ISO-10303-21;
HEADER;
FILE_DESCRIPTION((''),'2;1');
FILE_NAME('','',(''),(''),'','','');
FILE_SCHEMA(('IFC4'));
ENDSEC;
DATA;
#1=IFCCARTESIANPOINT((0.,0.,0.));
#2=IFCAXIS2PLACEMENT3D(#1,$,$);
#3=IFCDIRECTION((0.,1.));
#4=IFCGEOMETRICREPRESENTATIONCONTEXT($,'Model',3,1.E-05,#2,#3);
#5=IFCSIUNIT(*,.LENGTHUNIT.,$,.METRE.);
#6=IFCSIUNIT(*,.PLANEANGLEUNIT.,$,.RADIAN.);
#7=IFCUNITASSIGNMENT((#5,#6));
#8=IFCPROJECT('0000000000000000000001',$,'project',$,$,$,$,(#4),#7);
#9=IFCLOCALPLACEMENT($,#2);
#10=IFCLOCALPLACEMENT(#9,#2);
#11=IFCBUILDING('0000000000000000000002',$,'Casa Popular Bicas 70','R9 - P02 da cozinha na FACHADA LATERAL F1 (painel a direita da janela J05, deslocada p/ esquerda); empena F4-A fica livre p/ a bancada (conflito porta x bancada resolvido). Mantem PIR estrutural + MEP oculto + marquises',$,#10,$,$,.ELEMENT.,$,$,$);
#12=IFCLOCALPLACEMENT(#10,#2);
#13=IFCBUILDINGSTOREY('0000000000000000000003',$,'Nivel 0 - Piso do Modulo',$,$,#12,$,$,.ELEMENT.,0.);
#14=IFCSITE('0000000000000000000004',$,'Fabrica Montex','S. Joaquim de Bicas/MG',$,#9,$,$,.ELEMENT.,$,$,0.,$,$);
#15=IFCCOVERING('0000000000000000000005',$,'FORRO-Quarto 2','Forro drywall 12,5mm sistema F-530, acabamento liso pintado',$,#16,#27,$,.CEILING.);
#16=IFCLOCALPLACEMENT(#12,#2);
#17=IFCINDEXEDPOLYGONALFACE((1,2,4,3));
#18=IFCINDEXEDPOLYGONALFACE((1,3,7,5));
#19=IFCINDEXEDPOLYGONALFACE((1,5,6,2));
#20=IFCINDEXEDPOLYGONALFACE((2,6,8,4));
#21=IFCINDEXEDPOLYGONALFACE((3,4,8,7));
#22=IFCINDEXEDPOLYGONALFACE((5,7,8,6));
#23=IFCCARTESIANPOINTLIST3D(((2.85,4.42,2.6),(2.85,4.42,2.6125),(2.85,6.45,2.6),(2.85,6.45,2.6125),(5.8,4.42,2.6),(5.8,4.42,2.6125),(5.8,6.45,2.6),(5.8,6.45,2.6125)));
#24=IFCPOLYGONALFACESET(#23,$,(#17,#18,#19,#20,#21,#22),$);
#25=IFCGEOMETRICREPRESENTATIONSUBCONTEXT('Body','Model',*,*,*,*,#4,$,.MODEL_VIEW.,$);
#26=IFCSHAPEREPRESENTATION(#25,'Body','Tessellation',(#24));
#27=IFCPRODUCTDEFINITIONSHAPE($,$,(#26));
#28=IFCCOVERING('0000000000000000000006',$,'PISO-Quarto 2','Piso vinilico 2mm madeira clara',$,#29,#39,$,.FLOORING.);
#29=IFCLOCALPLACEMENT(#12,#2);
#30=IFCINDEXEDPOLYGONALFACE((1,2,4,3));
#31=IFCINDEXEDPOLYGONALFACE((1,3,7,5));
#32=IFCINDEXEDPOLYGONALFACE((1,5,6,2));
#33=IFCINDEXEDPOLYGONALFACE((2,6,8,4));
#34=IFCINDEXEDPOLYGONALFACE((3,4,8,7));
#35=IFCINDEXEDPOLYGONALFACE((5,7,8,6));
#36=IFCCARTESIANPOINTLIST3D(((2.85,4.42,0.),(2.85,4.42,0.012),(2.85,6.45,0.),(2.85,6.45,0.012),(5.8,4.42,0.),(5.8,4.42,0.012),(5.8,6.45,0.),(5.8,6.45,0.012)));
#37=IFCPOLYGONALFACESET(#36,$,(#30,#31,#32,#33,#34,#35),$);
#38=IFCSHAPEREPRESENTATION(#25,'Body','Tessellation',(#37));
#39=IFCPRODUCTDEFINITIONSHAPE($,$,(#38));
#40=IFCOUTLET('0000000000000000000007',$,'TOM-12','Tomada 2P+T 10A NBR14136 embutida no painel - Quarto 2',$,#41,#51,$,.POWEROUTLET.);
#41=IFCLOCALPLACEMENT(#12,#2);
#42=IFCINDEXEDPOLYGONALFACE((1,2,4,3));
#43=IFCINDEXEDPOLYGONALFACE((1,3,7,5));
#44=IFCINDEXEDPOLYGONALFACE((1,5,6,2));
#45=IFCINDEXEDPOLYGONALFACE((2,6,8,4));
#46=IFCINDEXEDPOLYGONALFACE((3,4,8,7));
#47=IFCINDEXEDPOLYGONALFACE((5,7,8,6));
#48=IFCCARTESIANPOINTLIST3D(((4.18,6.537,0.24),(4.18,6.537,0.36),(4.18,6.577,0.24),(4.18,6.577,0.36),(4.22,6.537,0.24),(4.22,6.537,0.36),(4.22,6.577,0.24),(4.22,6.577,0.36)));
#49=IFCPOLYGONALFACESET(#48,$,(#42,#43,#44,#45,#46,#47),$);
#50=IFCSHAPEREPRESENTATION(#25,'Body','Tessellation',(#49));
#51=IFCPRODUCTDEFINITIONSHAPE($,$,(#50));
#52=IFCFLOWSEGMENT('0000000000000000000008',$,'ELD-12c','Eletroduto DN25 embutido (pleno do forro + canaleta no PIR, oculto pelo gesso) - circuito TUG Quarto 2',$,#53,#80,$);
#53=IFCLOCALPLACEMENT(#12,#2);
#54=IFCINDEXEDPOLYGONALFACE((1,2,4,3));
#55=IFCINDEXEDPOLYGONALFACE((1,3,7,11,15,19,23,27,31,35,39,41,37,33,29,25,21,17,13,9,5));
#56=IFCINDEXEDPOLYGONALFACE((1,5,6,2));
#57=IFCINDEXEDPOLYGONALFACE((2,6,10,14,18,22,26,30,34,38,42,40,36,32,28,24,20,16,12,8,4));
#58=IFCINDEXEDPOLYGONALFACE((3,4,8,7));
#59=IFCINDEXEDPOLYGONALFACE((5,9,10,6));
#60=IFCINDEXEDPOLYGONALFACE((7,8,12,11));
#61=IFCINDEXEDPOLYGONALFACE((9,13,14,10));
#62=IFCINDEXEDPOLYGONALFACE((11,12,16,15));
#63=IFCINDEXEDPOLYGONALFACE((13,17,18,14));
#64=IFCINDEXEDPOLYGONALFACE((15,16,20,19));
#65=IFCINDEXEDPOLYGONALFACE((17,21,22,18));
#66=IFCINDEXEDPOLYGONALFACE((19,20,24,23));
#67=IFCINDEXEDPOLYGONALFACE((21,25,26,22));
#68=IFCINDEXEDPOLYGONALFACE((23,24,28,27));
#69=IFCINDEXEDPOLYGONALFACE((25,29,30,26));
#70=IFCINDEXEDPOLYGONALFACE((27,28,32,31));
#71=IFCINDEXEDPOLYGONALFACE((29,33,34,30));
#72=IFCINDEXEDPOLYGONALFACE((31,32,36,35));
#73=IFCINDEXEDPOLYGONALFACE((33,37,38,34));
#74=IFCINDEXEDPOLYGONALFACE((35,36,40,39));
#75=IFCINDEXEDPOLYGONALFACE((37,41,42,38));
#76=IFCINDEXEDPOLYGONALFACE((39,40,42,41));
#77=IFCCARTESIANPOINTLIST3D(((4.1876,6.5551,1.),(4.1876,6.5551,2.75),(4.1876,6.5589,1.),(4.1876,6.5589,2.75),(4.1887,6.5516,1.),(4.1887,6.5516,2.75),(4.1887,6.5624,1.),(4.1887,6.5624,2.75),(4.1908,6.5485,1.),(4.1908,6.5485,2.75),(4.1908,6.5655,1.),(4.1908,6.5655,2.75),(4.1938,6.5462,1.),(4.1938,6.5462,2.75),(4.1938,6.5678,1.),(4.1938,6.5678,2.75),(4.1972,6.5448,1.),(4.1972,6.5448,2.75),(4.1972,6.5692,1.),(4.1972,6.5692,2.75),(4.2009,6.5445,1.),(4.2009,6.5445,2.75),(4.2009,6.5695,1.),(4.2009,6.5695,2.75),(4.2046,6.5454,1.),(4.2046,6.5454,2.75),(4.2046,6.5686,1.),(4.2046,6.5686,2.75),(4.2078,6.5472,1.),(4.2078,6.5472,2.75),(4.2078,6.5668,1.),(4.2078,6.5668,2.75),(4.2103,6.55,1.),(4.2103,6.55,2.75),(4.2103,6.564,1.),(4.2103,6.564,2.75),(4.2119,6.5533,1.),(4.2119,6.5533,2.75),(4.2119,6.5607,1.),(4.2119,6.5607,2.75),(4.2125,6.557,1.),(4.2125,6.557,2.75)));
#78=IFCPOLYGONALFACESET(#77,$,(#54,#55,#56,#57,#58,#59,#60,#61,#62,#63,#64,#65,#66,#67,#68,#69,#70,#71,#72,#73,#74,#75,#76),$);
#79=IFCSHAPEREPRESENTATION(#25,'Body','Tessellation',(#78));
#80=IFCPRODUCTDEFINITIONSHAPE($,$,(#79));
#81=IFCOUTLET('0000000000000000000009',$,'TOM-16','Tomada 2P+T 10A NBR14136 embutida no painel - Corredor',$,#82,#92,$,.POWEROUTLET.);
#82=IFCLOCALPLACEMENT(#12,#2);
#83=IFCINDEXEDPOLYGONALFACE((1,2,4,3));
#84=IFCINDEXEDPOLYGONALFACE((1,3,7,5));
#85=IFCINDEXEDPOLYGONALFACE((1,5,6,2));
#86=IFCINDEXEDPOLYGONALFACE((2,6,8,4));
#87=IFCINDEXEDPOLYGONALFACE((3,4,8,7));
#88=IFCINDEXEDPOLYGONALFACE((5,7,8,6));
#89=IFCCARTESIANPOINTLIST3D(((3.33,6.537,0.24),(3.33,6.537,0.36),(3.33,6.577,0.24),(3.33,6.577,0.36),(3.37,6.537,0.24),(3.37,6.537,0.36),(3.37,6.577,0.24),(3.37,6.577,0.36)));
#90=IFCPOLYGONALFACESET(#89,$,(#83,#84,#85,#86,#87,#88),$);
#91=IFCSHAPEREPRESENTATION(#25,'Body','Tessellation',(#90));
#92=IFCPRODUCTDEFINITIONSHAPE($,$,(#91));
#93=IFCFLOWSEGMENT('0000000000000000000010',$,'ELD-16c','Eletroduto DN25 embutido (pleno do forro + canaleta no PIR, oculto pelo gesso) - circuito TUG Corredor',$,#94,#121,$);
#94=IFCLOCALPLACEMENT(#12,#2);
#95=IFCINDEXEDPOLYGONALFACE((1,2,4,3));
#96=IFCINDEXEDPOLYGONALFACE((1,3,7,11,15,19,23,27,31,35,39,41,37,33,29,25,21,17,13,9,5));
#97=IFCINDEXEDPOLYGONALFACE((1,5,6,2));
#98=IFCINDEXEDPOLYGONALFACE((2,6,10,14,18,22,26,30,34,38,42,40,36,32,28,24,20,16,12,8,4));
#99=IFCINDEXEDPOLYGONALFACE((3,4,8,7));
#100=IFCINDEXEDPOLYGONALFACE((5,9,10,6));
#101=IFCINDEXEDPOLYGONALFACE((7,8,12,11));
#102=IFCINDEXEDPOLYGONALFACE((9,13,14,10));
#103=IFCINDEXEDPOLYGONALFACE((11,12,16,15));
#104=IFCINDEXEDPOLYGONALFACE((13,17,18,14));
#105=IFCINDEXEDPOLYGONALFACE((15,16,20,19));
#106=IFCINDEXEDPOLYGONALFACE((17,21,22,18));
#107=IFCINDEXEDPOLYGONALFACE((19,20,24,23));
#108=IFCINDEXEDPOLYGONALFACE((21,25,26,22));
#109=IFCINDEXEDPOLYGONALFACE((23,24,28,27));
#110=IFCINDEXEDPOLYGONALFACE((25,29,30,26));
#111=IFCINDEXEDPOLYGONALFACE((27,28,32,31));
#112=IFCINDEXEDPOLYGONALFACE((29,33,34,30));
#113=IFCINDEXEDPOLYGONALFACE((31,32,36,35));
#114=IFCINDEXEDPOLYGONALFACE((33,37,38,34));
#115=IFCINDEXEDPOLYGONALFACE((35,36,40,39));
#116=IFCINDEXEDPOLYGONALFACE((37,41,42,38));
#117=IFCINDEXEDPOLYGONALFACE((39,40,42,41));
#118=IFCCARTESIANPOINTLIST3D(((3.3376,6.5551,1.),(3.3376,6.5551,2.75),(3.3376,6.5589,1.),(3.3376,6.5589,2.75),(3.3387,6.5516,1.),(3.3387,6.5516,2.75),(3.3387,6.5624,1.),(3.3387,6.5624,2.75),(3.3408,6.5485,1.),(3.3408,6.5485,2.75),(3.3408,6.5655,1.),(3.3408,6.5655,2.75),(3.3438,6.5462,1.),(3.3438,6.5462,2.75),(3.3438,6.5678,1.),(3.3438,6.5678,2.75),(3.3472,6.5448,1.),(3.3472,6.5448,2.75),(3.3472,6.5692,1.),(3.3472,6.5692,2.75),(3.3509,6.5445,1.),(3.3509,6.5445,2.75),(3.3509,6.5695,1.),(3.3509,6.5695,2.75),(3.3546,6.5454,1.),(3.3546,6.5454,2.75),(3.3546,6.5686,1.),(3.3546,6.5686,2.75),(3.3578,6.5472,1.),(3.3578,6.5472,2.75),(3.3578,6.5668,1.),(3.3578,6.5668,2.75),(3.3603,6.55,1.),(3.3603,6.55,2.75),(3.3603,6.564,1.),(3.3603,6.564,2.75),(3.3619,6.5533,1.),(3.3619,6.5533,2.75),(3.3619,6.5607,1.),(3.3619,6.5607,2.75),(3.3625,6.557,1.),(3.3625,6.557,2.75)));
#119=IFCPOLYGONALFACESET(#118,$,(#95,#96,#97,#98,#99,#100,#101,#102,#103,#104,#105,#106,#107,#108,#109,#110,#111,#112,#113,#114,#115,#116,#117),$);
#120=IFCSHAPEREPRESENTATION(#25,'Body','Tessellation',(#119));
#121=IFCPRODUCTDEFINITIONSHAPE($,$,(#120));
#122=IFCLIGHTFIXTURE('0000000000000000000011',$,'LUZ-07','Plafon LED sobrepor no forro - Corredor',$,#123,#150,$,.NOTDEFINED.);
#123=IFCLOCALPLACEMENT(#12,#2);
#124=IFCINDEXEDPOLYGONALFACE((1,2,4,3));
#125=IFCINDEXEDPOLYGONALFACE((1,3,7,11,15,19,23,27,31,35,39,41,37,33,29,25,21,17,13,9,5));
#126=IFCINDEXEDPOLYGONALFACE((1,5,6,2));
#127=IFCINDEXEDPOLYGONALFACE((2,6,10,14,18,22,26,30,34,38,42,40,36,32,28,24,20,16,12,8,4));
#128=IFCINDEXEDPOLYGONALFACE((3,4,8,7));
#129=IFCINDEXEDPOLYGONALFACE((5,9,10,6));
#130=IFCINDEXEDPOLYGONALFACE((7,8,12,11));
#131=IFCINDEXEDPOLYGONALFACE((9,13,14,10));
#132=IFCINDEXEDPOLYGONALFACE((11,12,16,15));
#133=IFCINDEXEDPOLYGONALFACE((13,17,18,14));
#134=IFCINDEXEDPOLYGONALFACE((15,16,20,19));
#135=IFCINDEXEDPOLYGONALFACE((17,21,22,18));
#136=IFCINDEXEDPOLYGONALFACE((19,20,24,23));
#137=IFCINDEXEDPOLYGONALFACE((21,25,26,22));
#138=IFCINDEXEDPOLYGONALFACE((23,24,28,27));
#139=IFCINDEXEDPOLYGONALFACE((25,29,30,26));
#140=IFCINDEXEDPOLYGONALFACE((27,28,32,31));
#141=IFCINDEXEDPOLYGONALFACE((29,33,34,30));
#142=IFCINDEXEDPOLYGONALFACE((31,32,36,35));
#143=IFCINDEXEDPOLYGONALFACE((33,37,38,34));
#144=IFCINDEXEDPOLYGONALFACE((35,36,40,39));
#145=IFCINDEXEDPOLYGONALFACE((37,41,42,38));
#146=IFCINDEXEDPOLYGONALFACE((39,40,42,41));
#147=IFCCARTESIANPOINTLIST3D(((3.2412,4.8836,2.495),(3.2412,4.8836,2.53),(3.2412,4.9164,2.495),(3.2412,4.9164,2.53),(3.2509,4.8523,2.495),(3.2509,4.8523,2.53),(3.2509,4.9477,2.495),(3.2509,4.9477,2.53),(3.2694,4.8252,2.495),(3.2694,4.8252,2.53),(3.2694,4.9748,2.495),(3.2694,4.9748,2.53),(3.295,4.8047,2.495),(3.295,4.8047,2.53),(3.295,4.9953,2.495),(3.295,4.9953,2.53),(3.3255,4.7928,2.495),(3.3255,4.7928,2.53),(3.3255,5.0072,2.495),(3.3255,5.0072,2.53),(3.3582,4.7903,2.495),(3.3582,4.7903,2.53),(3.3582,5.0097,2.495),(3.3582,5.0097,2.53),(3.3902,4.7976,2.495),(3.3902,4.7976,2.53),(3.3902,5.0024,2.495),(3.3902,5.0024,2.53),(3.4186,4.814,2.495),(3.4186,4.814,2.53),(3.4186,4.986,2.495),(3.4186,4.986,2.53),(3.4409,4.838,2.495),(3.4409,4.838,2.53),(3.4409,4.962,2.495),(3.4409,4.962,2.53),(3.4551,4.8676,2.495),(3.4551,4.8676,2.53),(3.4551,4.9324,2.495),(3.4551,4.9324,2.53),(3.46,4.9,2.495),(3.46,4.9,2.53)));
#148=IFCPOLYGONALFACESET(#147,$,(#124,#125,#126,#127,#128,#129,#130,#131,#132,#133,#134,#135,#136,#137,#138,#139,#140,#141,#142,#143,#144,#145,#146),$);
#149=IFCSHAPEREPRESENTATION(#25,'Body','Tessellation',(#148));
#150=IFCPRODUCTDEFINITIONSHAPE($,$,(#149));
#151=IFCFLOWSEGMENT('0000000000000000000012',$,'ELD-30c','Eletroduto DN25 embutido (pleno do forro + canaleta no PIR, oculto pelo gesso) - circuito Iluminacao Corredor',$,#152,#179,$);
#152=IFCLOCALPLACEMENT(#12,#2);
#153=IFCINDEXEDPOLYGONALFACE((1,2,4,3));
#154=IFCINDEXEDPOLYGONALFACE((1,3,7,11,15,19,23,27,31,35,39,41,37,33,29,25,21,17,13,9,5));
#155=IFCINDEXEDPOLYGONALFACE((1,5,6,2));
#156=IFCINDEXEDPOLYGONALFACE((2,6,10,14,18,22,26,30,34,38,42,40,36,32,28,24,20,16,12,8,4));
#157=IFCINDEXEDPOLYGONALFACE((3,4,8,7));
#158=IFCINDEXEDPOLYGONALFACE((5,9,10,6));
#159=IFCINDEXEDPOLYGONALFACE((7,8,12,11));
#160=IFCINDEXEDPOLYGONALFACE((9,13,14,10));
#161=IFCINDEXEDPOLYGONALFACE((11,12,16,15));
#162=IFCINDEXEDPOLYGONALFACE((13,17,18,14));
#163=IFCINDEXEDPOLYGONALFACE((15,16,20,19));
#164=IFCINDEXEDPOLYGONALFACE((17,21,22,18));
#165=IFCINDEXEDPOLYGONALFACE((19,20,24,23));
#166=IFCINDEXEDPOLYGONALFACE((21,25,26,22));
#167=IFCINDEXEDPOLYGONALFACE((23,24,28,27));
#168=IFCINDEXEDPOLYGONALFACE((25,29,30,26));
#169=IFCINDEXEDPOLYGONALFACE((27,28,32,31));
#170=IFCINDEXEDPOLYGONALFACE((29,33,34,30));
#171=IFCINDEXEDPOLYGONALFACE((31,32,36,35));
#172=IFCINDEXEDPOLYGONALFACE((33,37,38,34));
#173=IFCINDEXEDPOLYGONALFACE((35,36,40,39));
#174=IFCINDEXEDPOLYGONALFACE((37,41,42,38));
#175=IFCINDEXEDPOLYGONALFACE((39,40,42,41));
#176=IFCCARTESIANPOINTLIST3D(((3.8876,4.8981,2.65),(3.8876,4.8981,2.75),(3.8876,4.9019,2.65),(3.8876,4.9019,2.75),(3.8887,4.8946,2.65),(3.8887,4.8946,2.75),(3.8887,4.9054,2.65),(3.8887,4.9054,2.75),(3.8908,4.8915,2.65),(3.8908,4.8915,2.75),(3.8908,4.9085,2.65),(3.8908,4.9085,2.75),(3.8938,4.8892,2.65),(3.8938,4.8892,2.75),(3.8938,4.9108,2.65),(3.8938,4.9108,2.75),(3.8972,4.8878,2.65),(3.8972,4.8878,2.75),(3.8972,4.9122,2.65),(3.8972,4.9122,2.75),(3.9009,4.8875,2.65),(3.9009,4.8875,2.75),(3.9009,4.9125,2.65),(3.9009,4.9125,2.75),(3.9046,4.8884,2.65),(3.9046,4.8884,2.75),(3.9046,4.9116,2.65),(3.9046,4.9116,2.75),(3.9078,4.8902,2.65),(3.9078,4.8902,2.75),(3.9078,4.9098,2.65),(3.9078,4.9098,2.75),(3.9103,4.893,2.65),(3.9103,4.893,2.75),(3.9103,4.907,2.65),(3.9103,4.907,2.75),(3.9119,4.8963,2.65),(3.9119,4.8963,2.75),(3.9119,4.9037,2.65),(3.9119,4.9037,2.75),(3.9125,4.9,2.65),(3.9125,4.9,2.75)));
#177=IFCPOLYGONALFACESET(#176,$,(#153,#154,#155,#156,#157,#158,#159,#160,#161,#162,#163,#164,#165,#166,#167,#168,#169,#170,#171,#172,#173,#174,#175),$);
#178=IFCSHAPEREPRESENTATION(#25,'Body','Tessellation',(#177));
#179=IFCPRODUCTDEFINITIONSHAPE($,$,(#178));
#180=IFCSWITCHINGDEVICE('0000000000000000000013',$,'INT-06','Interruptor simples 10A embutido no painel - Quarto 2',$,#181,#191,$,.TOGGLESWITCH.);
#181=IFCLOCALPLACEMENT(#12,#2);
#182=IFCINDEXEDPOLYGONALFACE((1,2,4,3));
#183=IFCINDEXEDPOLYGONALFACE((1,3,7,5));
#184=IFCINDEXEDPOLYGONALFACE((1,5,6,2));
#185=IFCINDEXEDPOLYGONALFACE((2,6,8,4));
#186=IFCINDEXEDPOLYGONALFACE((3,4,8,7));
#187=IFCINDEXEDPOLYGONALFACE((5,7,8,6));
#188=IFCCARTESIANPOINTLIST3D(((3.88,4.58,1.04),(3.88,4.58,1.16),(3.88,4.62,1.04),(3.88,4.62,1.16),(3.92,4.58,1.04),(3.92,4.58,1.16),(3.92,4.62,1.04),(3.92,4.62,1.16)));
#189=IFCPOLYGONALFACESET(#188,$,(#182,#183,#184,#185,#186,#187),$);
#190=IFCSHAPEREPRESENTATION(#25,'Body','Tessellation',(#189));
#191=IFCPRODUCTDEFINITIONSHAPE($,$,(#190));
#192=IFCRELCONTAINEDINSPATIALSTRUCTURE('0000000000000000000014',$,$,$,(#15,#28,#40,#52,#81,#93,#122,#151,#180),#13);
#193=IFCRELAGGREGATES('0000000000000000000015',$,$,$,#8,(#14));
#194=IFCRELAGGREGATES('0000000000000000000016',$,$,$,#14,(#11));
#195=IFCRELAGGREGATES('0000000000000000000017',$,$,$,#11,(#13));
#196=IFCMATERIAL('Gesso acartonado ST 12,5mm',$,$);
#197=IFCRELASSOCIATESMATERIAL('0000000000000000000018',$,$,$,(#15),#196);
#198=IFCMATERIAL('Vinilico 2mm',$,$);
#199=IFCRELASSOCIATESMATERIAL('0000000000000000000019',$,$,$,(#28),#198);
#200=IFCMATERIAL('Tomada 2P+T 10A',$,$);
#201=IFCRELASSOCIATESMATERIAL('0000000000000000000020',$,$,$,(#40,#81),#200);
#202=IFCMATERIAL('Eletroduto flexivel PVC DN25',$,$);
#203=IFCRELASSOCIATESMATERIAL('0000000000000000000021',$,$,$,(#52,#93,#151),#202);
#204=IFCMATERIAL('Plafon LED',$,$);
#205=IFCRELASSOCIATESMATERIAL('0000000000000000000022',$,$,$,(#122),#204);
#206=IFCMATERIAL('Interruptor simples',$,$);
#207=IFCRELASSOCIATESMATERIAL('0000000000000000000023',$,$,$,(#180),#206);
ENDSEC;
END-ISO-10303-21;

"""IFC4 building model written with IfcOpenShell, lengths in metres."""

from ifc_helpers import new_model, si_unit, direction, frame, frame_2d, origin, origin_2d, place, context, subcontext, project, spatial, rectangle, circle, extrude, material, element, save


model = new_model("IFC4")

# Units and contexts
model_context = context("Model", 3, precision=1e-05, world=origin(), true_north=direction((0.0, 1.0)))
body_context = subcontext(model_context, "Body", "Model", "MODEL_VIEW")
ifc_project = project(units=[si_unit("LENGTHUNIT", "METRE"), si_unit("PLANEANGLEUNIT", "RADIAN")], contexts=[model_context])

# Site, building, storey
site_placement = place(None, origin())
site = spatial("IfcSite", under=ifc_project, at=site_placement, Name="Fabrica Montex", Description="S. Joaquim de Bicas/MG", CompositionType="ELEMENT", RefElevation=0.0)
building_placement = place(site_placement, origin())
building = spatial("IfcBuilding", under=site, at=building_placement, Name="Casa Popular Bicas 70", Description="R9 - P02 da cozinha na FACHADA LATERAL F1 (painel a direita da janela J05, deslocada p/ esquerda); empena F4-A fica livre p/ a bancada (conflito porta x bancada resolvido). Mantem PIR estrutural + MEP oculto + marquises", CompositionType="ELEMENT")
storey_placement = place(building_placement, origin())
storey = spatial("IfcBuildingStorey", under=building, at=storey_placement, Name="Nivel 0 - Piso do Modulo", CompositionType="ELEMENT", Elevation=0.0)

# Coverings
ifc_material_1 = material(Name="Gesso acartonado ST 12,5mm")
covering_1_placement = place(storey_placement, frame((2.85, 4.42, 2.6)))
element("IfcCovering", 1, at=covering_1_placement, inside=storey, material=ifc_material_1, Name="FORRO-Quarto 2", Description="Forro drywall 12,5mm sistema F-530, acabamento liso pintado", PredefinedType="CEILING", context=body_context, shape_type="SweptSolid", body=[
    extrude(rectangle(XDim=2.95, YDim=2.03, at=frame_2d((1.475, 1.015))), origin(), (0.0, 0.0, 1.0), 0.0125),
])
ifc_material_2 = material(Name="Vinilico 2mm")
covering_2_placement = place(storey_placement, frame((2.85, 4.42, 0.0)))
element("IfcCovering", 2, at=covering_2_placement, inside=storey, material=ifc_material_2, Name="PISO-Quarto 2", Description="Piso vinilico 2mm madeira clara", PredefinedType="FLOORING", context=body_context, shape_type="SweptSolid", body=[
    extrude(rectangle(XDim=2.95, YDim=2.03, at=frame_2d((1.475, 1.015))), origin(), (0.0, 0.0, 1.0), 0.012),
])

# Outlet
ifc_material_3 = material(Name="Tomada 2P+T 10A")
outlet_1_placement = place(storey_placement, frame((4.18, 6.537, 0.24)))
element("IfcOutlet", 3, at=outlet_1_placement, inside=storey, material=ifc_material_3, Name="TOM-12", Description="Tomada 2P+T 10A NBR14136 embutida no painel - Quarto 2", PredefinedType="POWEROUTLET", context=body_context, shape_type="SweptSolid", body=[
    extrude(rectangle(XDim=0.04, YDim=0.04, at=frame_2d((0.02, 0.02))), origin(), (0.0, 0.0, 1.0), 0.12),
])

# Flow segment
ifc_material_4 = material(Name="Eletroduto flexivel PVC DN25")
flow_segment_1_placement = place(storey_placement, frame((4.2, 6.557, 2.75), z_axis=(0.0, 0.0, -1.0), x_axis=(1.0, 0.0, 0.0)))
element("IfcFlowSegment", 4, at=flow_segment_1_placement, inside=storey, material=ifc_material_4, Name="ELD-12c", Description="Eletroduto DN25 embutido (pleno do forro + canaleta no PIR, oculto pelo gesso) - circuito TUG Quarto 2", context=body_context, shape_type="SweptSolid", body=[
    extrude(circle(Radius=0.0125, at=origin_2d()), origin(), (0.0, 0.0, 1.0), 1.75),
])

# Outlet
outlet_2_placement = place(storey_placement, frame((3.33, 6.537, 0.24)))
element("IfcOutlet", 5, at=outlet_2_placement, inside=storey, material=ifc_material_3, Name="TOM-16", Description="Tomada 2P+T 10A NBR14136 embutida no painel - Corredor", PredefinedType="POWEROUTLET", context=body_context, shape_type="SweptSolid", body=[
    extrude(rectangle(XDim=0.04, YDim=0.04, at=frame_2d((0.02, 0.02))), origin(), (0.0, 0.0, 1.0), 0.12),
])

# Flow segment
flow_segment_2_placement = place(storey_placement, frame((3.35, 6.557, 2.75), z_axis=(0.0, 0.0, -1.0), x_axis=(1.0, 0.0, 0.0)))
element("IfcFlowSegment", 6, at=flow_segment_2_placement, inside=storey, material=ifc_material_4, Name="ELD-16c", Description="Eletroduto DN25 embutido (pleno do forro + canaleta no PIR, oculto pelo gesso) - circuito TUG Corredor", context=body_context, shape_type="SweptSolid", body=[
    extrude(circle(Radius=0.0125, at=origin_2d()), origin(), (0.0, 0.0, 1.0), 1.75),
])

# Light fixture
ifc_material_5 = material(Name="Plafon LED")
light_fixture_placement = place(storey_placement, frame((3.35, 4.9, 2.495)))
element("IfcLightFixture", 7, at=light_fixture_placement, inside=storey, material=ifc_material_5, Name="LUZ-07", Description="Plafon LED sobrepor no forro - Corredor", PredefinedType="NOTDEFINED", context=body_context, shape_type="SweptSolid", body=[
    extrude(circle(Radius=0.11, at=origin_2d()), origin(), (0.0, 0.0, 1.0), 0.035),
])

# Flow segment
flow_segment_3_placement = place(storey_placement, frame((3.9, 4.9, 2.75), z_axis=(0.0, 0.0, -1.0), x_axis=(1.0, 0.0, 0.0)))
element("IfcFlowSegment", 8, at=flow_segment_3_placement, inside=storey, material=ifc_material_4, Name="ELD-30c", Description="Eletroduto DN25 embutido (pleno do forro + canaleta no PIR, oculto pelo gesso) - circuito Iluminacao Corredor", context=body_context, shape_type="SweptSolid", body=[
    extrude(circle(Radius=0.0125, at=origin_2d()), origin(), (0.0, 0.0, 1.0), 0.1),
])

# Switching device
ifc_material_6 = material(Name="Interruptor simples")
switching_device_placement = place(storey_placement, frame((3.88, 4.58, 1.04)))
element("IfcSwitchingDevice", 9, at=switching_device_placement, inside=storey, material=ifc_material_6, Name="INT-06", Description="Interruptor simples 10A embutido no painel - Quarto 2", PredefinedType="TOGGLESWITCH", context=body_context, shape_type="SweptSolid", body=[
    extrude(rectangle(XDim=0.04, YDim=0.04, at=frame_2d((0.02, 0.02))), origin(), (0.0, 0.0, 1.0), 0.12),
])

save(model, "model.ifc")
